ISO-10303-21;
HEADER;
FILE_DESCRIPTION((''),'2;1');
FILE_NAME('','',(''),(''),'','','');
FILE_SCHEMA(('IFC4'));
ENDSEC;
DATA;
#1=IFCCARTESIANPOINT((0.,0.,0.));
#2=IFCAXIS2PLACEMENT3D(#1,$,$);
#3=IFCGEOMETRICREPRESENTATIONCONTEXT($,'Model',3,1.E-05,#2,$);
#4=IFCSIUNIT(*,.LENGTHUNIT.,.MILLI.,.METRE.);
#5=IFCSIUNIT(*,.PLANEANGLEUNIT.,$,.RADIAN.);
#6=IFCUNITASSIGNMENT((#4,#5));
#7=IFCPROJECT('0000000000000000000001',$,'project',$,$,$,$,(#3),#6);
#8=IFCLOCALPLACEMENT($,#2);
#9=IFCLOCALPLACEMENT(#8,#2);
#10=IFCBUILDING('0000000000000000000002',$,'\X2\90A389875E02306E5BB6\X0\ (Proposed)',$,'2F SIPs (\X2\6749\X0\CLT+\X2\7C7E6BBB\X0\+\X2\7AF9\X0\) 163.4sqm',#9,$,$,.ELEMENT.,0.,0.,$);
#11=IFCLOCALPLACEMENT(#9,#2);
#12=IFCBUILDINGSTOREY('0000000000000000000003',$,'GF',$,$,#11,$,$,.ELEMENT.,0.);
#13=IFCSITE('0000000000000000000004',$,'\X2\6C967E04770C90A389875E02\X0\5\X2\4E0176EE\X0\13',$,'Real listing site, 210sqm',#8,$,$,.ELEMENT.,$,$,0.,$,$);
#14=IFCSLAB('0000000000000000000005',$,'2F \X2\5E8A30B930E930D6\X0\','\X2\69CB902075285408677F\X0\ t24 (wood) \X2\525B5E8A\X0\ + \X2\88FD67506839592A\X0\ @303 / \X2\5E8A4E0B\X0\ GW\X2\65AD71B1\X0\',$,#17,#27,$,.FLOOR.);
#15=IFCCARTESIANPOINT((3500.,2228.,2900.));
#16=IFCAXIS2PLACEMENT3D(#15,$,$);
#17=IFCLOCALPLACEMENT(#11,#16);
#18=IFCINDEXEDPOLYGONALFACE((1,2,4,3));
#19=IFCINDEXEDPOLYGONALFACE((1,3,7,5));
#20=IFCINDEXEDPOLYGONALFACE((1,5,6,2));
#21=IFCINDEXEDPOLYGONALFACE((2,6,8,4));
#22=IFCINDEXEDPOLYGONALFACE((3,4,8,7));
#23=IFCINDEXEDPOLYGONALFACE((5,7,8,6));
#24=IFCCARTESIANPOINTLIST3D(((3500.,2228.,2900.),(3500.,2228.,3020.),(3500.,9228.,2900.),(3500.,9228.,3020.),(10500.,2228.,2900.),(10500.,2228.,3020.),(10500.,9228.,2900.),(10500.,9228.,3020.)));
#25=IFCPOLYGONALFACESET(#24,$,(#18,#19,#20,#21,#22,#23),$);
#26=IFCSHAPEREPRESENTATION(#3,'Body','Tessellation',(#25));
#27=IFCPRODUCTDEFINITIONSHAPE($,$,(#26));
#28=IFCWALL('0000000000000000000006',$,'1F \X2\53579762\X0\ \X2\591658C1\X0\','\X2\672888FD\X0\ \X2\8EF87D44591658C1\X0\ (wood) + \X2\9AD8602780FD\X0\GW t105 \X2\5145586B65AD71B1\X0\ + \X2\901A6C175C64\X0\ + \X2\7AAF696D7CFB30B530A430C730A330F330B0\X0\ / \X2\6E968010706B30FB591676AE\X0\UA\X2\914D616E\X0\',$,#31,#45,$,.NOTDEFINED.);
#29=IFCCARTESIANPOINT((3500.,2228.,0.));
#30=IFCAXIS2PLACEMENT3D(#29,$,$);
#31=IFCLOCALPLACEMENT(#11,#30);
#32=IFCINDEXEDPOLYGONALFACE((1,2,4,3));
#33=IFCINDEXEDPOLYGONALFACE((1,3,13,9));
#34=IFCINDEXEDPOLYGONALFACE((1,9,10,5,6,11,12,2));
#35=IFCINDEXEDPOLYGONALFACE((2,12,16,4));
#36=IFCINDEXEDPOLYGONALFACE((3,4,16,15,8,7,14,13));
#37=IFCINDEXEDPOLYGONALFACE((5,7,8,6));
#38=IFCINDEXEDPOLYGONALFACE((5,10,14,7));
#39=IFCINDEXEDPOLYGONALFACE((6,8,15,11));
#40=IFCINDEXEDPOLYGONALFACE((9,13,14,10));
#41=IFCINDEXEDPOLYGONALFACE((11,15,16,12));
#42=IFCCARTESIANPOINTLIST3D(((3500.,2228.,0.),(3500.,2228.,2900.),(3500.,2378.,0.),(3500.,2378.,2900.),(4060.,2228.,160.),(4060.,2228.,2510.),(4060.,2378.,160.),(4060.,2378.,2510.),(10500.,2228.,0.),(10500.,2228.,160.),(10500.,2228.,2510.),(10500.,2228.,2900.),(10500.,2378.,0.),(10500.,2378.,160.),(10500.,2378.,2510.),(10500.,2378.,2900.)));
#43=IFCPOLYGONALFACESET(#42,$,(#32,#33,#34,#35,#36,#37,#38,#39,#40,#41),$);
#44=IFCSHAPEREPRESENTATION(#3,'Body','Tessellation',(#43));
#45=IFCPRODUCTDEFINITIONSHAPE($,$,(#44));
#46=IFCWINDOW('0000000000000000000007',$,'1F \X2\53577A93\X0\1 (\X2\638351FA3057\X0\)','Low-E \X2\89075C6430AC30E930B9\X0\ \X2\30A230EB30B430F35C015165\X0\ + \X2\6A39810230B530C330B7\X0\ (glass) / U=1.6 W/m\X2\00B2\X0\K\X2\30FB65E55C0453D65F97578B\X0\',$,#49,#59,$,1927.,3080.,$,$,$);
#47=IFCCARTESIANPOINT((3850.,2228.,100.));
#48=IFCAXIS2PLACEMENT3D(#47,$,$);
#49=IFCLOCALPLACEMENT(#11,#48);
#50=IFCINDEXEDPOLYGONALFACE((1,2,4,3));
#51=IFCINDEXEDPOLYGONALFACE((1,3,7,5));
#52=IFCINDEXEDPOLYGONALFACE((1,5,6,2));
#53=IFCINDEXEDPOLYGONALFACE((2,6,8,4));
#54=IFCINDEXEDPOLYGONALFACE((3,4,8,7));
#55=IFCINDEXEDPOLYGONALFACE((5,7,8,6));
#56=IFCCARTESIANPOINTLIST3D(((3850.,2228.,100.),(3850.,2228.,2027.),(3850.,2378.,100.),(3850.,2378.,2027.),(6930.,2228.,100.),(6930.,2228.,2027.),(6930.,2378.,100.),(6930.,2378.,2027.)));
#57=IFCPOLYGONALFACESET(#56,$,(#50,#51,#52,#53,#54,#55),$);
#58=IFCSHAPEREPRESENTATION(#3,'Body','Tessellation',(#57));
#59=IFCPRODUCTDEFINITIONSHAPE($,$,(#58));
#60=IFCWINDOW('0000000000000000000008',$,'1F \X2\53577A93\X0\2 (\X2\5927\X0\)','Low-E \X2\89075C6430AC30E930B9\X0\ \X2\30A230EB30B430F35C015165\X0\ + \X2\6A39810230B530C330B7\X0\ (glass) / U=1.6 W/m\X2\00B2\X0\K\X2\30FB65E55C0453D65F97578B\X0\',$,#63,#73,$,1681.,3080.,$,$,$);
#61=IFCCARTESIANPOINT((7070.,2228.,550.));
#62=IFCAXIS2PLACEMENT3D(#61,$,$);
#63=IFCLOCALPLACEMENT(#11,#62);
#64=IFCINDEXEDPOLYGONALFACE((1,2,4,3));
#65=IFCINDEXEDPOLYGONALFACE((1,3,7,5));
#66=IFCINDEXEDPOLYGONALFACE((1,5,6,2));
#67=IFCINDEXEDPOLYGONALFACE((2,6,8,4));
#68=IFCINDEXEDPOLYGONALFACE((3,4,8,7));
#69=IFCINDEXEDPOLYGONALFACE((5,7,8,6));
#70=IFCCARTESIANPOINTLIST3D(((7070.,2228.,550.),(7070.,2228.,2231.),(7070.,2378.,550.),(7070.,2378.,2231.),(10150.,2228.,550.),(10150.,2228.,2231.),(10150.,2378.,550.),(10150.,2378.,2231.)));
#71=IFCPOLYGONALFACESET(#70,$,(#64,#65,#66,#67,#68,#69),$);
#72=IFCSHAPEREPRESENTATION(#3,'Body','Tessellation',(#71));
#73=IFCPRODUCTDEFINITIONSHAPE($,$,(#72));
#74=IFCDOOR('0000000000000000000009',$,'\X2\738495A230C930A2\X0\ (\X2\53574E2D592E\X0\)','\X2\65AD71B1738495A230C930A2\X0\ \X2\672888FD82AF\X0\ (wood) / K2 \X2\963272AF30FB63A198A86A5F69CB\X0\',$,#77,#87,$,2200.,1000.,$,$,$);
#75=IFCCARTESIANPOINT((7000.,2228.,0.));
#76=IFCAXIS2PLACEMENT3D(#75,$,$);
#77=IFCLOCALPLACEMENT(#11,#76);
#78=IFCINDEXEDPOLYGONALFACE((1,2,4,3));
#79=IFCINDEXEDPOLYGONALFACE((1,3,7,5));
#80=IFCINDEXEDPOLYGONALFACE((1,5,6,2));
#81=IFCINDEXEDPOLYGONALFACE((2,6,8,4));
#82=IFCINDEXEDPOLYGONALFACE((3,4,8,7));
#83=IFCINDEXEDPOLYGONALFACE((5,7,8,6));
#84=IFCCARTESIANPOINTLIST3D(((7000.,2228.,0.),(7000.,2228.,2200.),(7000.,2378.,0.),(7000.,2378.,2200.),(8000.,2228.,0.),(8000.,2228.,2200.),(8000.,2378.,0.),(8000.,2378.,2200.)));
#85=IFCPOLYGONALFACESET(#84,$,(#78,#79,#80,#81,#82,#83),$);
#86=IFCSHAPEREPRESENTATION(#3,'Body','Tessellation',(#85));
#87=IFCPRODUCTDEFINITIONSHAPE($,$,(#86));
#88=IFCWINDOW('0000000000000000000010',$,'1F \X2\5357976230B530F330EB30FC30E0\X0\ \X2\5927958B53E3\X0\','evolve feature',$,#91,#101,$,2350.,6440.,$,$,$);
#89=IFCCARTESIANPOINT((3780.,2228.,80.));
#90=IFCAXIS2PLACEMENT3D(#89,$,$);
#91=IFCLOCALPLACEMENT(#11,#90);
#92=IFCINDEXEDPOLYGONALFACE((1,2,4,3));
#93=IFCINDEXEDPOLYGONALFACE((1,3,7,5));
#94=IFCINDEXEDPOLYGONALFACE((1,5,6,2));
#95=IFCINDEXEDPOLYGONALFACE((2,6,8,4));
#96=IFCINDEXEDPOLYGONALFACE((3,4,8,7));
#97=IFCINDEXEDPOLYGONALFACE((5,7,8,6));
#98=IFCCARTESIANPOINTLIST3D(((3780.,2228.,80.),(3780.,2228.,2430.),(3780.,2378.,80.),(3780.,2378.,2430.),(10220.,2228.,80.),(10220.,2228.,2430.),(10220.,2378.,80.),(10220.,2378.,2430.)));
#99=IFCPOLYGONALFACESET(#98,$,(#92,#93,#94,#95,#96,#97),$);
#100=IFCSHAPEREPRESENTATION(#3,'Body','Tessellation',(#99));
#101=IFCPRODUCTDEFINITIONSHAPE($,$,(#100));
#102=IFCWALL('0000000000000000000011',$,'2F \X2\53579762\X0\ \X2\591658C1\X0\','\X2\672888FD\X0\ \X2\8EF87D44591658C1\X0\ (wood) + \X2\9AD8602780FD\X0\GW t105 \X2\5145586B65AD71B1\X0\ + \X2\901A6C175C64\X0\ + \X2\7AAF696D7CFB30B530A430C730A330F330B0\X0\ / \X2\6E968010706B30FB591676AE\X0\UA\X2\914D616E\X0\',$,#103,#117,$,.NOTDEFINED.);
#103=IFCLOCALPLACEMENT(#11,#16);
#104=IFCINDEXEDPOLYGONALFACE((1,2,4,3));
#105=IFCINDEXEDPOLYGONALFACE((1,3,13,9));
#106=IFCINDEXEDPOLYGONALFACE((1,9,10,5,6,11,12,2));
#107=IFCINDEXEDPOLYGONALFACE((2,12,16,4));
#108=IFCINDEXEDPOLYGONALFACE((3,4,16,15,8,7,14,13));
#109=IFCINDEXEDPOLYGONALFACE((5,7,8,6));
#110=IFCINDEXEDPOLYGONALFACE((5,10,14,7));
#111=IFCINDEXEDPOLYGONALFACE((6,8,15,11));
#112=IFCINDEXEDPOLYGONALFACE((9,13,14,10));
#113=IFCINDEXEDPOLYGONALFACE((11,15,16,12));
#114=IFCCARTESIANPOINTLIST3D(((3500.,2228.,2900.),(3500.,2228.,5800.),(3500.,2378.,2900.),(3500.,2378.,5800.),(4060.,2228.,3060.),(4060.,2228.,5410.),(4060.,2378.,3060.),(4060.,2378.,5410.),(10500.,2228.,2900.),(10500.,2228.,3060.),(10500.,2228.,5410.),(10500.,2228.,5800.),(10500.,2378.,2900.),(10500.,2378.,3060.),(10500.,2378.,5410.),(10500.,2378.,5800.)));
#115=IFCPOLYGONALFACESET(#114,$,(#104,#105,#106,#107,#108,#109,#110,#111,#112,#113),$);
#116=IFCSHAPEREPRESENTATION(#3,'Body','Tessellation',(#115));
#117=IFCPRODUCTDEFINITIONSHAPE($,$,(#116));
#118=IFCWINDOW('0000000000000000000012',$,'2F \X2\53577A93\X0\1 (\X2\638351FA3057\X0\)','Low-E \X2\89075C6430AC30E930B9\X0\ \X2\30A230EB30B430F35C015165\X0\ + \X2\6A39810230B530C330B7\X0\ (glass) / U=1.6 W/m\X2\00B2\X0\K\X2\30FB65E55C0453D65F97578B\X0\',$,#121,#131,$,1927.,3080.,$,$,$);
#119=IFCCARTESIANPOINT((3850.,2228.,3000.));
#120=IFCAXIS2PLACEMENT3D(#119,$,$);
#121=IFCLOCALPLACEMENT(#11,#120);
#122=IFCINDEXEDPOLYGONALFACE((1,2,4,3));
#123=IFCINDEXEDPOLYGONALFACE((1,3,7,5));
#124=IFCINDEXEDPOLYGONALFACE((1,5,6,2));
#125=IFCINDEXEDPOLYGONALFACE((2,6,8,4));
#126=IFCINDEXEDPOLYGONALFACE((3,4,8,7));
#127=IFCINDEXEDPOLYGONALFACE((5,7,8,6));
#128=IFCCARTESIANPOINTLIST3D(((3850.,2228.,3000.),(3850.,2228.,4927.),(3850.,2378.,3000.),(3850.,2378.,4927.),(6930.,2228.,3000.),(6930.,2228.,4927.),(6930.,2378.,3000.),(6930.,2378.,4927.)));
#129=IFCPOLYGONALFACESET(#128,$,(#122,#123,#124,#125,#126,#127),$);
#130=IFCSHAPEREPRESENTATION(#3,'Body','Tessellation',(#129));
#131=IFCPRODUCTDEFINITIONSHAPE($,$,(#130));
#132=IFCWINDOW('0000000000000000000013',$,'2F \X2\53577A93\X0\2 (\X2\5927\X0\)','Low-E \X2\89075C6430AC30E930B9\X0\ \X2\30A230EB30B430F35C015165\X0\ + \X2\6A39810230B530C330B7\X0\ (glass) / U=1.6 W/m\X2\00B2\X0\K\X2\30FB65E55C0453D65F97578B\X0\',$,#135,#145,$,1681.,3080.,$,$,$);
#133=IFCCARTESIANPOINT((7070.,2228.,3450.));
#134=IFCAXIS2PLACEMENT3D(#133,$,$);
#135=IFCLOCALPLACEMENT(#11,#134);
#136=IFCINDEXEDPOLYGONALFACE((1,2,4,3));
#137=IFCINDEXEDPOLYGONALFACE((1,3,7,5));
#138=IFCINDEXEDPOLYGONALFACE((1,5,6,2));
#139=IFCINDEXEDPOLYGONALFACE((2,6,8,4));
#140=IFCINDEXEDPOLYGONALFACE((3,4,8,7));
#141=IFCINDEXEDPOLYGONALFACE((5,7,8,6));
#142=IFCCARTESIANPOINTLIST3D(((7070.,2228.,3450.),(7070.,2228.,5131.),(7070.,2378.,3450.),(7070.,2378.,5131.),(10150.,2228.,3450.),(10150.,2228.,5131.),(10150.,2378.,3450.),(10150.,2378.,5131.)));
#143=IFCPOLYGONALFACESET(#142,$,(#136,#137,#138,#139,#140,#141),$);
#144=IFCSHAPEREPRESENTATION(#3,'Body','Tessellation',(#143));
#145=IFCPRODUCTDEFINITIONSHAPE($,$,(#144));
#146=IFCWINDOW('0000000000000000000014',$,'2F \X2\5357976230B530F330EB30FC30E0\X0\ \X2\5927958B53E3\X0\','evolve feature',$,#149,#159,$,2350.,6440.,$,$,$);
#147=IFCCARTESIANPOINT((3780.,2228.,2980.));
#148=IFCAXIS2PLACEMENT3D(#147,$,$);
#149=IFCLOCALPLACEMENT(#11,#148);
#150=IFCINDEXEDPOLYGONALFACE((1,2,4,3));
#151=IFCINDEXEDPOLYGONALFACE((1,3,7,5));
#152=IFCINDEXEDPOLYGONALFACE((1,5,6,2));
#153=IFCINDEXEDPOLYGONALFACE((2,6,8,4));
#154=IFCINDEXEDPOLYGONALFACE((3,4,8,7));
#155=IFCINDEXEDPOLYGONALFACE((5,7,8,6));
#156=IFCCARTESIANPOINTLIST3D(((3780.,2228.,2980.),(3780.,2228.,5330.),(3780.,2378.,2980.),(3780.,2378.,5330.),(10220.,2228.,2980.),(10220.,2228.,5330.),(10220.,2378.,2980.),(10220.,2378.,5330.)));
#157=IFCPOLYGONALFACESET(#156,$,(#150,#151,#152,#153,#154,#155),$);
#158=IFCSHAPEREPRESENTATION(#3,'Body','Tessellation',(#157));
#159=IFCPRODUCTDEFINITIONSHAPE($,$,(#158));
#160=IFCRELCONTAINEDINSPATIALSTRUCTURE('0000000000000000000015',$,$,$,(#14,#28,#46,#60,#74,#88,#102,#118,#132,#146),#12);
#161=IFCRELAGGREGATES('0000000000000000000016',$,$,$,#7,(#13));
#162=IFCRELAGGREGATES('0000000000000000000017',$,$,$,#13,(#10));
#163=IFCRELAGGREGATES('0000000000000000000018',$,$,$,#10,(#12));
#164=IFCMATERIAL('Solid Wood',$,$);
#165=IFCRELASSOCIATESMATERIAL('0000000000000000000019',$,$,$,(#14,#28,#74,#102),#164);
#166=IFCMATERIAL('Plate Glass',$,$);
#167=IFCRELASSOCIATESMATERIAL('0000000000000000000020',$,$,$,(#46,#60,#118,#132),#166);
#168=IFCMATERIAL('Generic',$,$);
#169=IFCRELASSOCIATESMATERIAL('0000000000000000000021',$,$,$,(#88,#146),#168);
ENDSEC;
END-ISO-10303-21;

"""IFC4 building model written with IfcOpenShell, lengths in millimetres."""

from ifc_helpers import new_model, si_unit, frame, frame_2d, origin, place, context, project, spatial, rectangle, extrude, material, element, fill, save


model = new_model("IFC4")

# Units and contexts
model_context = context("Model", 3, precision=1e-05, world=origin())
ifc_project = project(units=[si_unit("LENGTHUNIT", "METRE", prefix="MILLI"), si_unit("PLANEANGLEUNIT", "RADIAN")], contexts=[model_context])

# Site, building, storey
site_placement = place(None, origin())
site = spatial("IfcSite", under=ifc_project, at=site_placement, Name="沖縄県那覇市5丁目13", ObjectType="Real listing site, 210sqm", CompositionType="ELEMENT", RefElevation=0.0)
building_placement = place(site_placement, origin())
building = spatial("IfcBuilding", under=site, at=building_placement, Name="那覇市の家 (Proposed)", ObjectType="2F SIPs (杉CLT+籾殻+竹) 163.4sqm", CompositionType="ELEMENT", ElevationOfRefHeight=0.0, ElevationOfTerrain=0.0)
storey_placement = place(building_placement, origin())
storey = spatial("IfcBuildingStorey", under=building, at=storey_placement, Name="GF", CompositionType="ELEMENT", Elevation=0.0)

# Slab
ifc_material_1 = material(Name="Solid Wood")
slab_1_placement = place(storey_placement, frame((3500.0, 2228.0, 2900.0)))
element("IfcSlab", 1, at=slab_1_placement, inside=storey, material=ifc_material_1, Name="2F 床スラブ", Description="構造用合板 t24 (wood) 剛床 + 製材根太 @303 / 床下 GW断熱", PredefinedType="FLOOR", context=model_context, shape_type="SweptSolid", body=[
    extrude(rectangle(XDim=7000.0, YDim=7000.0, at=frame_2d((3500.0, 3500.0))), frame((3500.0, 2228.0, 2900.0)), (0.0, 0.0, 1.0), 120.0),
])
ifc_material_2 = material(Name="Generic")

# Wall, openings, windows, door
wall_1_placement = place(storey_placement, frame((3500.0, 2228.0, 0.0)))
wall_1 = element("IfcWall", 2, at=wall_1_placement, inside=storey, material=ifc_material_1, Name="1F 南面 外壁", Description="木製 軸組外壁 (wood) + 高性能GW t105 充填断熱 + 通気層 + 窯業系サイディング / 準耐火・外皮UA配慮", PredefinedType="NOTDEFINED", context=model_context, shape_type="SweptSolid", body=[
    extrude(rectangle(XDim=7000.0, YDim=150.0, at=frame_2d((3500.0, 75.0))), frame((3500.0, 2228.0, 0.0)), (0.0, 0.0, 1.0), 2900.0),
])
opening_1_placement = place(storey_placement, frame((3850.0, 2228.0, 100.0)))
opening_1 = element("IfcOpeningElement", 3, at=opening_1_placement, cuts=wall_1, PredefinedType="NOTDEFINED", context=model_context, shape_type="SweptSolid", body=[
    extrude(rectangle(XDim=3080.0, YDim=150.0, at=frame_2d((1540.0, 75.0))), frame((3850.0, 2228.0, 100.0)), (0.0, 0.0, 1.0), 1927.0),
])
opening_2_placement = place(storey_placement, frame((7070.0, 2228.0, 550.0)))
opening_2 = element("IfcOpeningElement", 4, at=opening_2_placement, cuts=wall_1, PredefinedType="NOTDEFINED", context=model_context, shape_type="SweptSolid", body=[
    extrude(rectangle(XDim=3080.0, YDim=150.0, at=frame_2d((1540.0, 75.0))), frame((7070.0, 2228.0, 550.0)), (0.0, 0.0, 1.0), 1681.0),
])
opening_3_placement = place(storey_placement, frame((7000.0, 2228.0, 0.0)))
opening_3 = element("IfcOpeningElement", 5, at=opening_3_placement, cuts=wall_1, PredefinedType="NOTDEFINED", context=model_context, shape_type="SweptSolid", body=[
    extrude(rectangle(XDim=1000.0, YDim=150.0, at=frame_2d((500.0, 75.0))), frame((7000.0, 2228.0, 0.0)), (0.0, 0.0, 1.0), 2200.0),
])
opening_4_placement = place(storey_placement, frame((3780.0, 2228.0, 80.0)))
opening_4 = element("IfcOpeningElement", 6, at=opening_4_placement, cuts=wall_1, PredefinedType="NOTDEFINED", context=model_context, shape_type="SweptSolid", body=[
    extrude(rectangle(XDim=6440.0, YDim=150.0, at=frame_2d((3220.0, 75.0))), frame((3780.0, 2228.0, 80.0)), (0.0, 0.0, 1.0), 2350.0),
])
ifc_material_3 = material(Name="Plate Glass")
window_1_placement = place(storey_placement, frame((3850.0, 2228.0, 100.0)))
window_1 = element("IfcWindow", 7, at=window_1_placement, inside=storey, material=ifc_material_3, Name="1F 南窓1 (掃出し)", Description="Low-E 複層ガラス アルゴン封入 + 樹脂サッシ (glass) / U=1.6 W/m²K・日射取得型", OverallHeight=1927.0, OverallWidth=3080.0, context=model_context, shape_type="SweptSolid", body=[
    extrude(rectangle(XDim=3080.0, YDim=150.0, at=frame_2d((1540.0, 75.0))), frame((3850.0, 2228.0, 100.0)), (0.0, 0.0, 1.0), 1927.0),
])
fill(opening_1, window_1)
window_2_placement = place(storey_placement, frame((7070.0, 2228.0, 550.0)))
window_2 = element("IfcWindow", 8, at=window_2_placement, inside=storey, material=ifc_material_3, Name="1F 南窓2 (大)", Description="Low-E 複層ガラス アルゴン封入 + 樹脂サッシ (glass) / U=1.6 W/m²K・日射取得型", OverallHeight=1681.0, OverallWidth=3080.0, context=model_context, shape_type="SweptSolid", body=[
    extrude(rectangle(XDim=3080.0, YDim=150.0, at=frame_2d((1540.0, 75.0))), frame((7070.0, 2228.0, 550.0)), (0.0, 0.0, 1.0), 1681.0),
])
fill(opening_2, window_2)
door_placement = place(storey_placement, frame((7000.0, 2228.0, 0.0)))
door = element("IfcDoor", 9, at=door_placement, inside=storey, material=ifc_material_1, Name="玄関ドア (南中央)", Description="断熱玄関ドア 木製芯 (wood) / K2 防犯・採風機構", OverallHeight=2200.0, OverallWidth=1000.0, context=model_context, shape_type="SweptSolid", body=[
    extrude(rectangle(XDim=1000.0, YDim=150.0, at=frame_2d((500.0, 75.0))), frame((7000.0, 2228.0, 0.0)), (0.0, 0.0, 1.0), 2200.0),
])
fill(opening_3, door)
window_3_placement = place(storey_placement, frame((3780.0, 2228.0, 80.0)))
window_3 = element("IfcWindow", 10, at=window_3_placement, inside=storey, material=ifc_material_2, Name="1F 南面サンルーム 大開口", Description="evolve feature", OverallHeight=2350.0, OverallWidth=6440.0, context=model_context, shape_type="SweptSolid", body=[
    extrude(rectangle(XDim=6440.0, YDim=150.0, at=frame_2d((3220.0, 75.0))), frame((3780.0, 2228.0, 80.0)), (0.0, 0.0, 1.0), 2350.0),
])
fill(opening_4, window_3)

# Wall, openings, windows
wall_2_placement = place(storey_placement, frame((3500.0, 2228.0, 2900.0)))
wall_2 = element("IfcWall", 11, at=wall_2_placement, inside=storey, material=ifc_material_1, Name="2F 南面 外壁", Description="木製 軸組外壁 (wood) + 高性能GW t105 充填断熱 + 通気層 + 窯業系サイディング / 準耐火・外皮UA配慮", PredefinedType="NOTDEFINED", context=model_context, shape_type="SweptSolid", body=[
    extrude(rectangle(XDim=7000.0, YDim=150.0, at=frame_2d((3500.0, 75.0))), frame((3500.0, 2228.0, 2900.0)), (0.0, 0.0, 1.0), 2900.0),
])
opening_5_placement = place(storey_placement, frame((3850.0, 2228.0, 3000.0)))
opening_5 = element("IfcOpeningElement", 12, at=opening_5_placement, cuts=wall_2, PredefinedType="NOTDEFINED", context=model_context, shape_type="SweptSolid", body=[
    extrude(rectangle(XDim=3080.0, YDim=150.0, at=frame_2d((1540.0, 75.0))), frame((3850.0, 2228.0, 3000.0)), (0.0, 0.0, 1.0), 1927.0),
])
opening_6_placement = place(storey_placement, frame((7070.0, 2228.0, 3450.0)))
opening_6 = element("IfcOpeningElement", 13, at=opening_6_placement, cuts=wall_2, PredefinedType="NOTDEFINED", context=model_context, shape_type="SweptSolid", body=[
    extrude(rectangle(XDim=3080.0, YDim=150.0, at=frame_2d((1540.0, 75.0))), frame((7070.0, 2228.0, 3450.0)), (0.0, 0.0, 1.0), 1681.0),
])
opening_7_placement = place(storey_placement, frame((3780.0, 2228.0, 2980.0)))
opening_7 = element("IfcOpeningElement", 14, at=opening_7_placement, cuts=wall_2, PredefinedType="NOTDEFINED", context=model_context, shape_type="SweptSolid", body=[
    extrude(rectangle(XDim=6440.0, YDim=150.0, at=frame_2d((3220.0, 75.0))), frame((3780.0, 2228.0, 2980.0)), (0.0, 0.0, 1.0), 2350.0),
])
window_4_placement = place(storey_placement, frame((3850.0, 2228.0, 3000.0)))
window_4 = element("IfcWindow", 15, at=window_4_placement, inside=storey, material=ifc_material_3, Name="2F 南窓1 (掃出し)", Description="Low-E 複層ガラス アルゴン封入 + 樹脂サッシ (glass) / U=1.6 W/m²K・日射取得型", OverallHeight=1927.0, OverallWidth=3080.0, context=model_context, shape_type="SweptSolid", body=[
    extrude(rectangle(XDim=3080.0, YDim=150.0, at=frame_2d((1540.0, 75.0))), frame((3850.0, 2228.0, 3000.0)), (0.0, 0.0, 1.0), 1927.0),
])
fill(opening_5, window_4)
window_5_placement = place(storey_placement, frame((7070.0, 2228.0, 3450.0)))
window_5 = element("IfcWindow", 16, at=window_5_placement, inside=storey, material=ifc_material_3, Name="2F 南窓2 (大)", Description="Low-E 複層ガラス アルゴン封入 + 樹脂サッシ (glass) / U=1.6 W/m²K・日射取得型", OverallHeight=1681.0, OverallWidth=3080.0, context=model_context, shape_type="SweptSolid", body=[
    extrude(rectangle(XDim=3080.0, YDim=150.0, at=frame_2d((1540.0, 75.0))), frame((7070.0, 2228.0, 3450.0)), (0.0, 0.0, 1.0), 1681.0),
])
fill(opening_6, window_5)
window_6_placement = place(storey_placement, frame((3780.0, 2228.0, 2980.0)))
window_6 = element("IfcWindow", 17, at=window_6_placement, inside=storey, material=ifc_material_2, Name="2F 南面サンルーム 大開口", Description="evolve feature", OverallHeight=2350.0, OverallWidth=6440.0, context=model_context, shape_type="SweptSolid", body=[
    extrude(rectangle(XDim=6440.0, YDim=150.0, at=frame_2d((3220.0, 75.0))), frame((3780.0, 2228.0, 2980.0)), (0.0, 0.0, 1.0), 2350.0),
])
fill(opening_7, window_6)

save(model, "model.ifc")
